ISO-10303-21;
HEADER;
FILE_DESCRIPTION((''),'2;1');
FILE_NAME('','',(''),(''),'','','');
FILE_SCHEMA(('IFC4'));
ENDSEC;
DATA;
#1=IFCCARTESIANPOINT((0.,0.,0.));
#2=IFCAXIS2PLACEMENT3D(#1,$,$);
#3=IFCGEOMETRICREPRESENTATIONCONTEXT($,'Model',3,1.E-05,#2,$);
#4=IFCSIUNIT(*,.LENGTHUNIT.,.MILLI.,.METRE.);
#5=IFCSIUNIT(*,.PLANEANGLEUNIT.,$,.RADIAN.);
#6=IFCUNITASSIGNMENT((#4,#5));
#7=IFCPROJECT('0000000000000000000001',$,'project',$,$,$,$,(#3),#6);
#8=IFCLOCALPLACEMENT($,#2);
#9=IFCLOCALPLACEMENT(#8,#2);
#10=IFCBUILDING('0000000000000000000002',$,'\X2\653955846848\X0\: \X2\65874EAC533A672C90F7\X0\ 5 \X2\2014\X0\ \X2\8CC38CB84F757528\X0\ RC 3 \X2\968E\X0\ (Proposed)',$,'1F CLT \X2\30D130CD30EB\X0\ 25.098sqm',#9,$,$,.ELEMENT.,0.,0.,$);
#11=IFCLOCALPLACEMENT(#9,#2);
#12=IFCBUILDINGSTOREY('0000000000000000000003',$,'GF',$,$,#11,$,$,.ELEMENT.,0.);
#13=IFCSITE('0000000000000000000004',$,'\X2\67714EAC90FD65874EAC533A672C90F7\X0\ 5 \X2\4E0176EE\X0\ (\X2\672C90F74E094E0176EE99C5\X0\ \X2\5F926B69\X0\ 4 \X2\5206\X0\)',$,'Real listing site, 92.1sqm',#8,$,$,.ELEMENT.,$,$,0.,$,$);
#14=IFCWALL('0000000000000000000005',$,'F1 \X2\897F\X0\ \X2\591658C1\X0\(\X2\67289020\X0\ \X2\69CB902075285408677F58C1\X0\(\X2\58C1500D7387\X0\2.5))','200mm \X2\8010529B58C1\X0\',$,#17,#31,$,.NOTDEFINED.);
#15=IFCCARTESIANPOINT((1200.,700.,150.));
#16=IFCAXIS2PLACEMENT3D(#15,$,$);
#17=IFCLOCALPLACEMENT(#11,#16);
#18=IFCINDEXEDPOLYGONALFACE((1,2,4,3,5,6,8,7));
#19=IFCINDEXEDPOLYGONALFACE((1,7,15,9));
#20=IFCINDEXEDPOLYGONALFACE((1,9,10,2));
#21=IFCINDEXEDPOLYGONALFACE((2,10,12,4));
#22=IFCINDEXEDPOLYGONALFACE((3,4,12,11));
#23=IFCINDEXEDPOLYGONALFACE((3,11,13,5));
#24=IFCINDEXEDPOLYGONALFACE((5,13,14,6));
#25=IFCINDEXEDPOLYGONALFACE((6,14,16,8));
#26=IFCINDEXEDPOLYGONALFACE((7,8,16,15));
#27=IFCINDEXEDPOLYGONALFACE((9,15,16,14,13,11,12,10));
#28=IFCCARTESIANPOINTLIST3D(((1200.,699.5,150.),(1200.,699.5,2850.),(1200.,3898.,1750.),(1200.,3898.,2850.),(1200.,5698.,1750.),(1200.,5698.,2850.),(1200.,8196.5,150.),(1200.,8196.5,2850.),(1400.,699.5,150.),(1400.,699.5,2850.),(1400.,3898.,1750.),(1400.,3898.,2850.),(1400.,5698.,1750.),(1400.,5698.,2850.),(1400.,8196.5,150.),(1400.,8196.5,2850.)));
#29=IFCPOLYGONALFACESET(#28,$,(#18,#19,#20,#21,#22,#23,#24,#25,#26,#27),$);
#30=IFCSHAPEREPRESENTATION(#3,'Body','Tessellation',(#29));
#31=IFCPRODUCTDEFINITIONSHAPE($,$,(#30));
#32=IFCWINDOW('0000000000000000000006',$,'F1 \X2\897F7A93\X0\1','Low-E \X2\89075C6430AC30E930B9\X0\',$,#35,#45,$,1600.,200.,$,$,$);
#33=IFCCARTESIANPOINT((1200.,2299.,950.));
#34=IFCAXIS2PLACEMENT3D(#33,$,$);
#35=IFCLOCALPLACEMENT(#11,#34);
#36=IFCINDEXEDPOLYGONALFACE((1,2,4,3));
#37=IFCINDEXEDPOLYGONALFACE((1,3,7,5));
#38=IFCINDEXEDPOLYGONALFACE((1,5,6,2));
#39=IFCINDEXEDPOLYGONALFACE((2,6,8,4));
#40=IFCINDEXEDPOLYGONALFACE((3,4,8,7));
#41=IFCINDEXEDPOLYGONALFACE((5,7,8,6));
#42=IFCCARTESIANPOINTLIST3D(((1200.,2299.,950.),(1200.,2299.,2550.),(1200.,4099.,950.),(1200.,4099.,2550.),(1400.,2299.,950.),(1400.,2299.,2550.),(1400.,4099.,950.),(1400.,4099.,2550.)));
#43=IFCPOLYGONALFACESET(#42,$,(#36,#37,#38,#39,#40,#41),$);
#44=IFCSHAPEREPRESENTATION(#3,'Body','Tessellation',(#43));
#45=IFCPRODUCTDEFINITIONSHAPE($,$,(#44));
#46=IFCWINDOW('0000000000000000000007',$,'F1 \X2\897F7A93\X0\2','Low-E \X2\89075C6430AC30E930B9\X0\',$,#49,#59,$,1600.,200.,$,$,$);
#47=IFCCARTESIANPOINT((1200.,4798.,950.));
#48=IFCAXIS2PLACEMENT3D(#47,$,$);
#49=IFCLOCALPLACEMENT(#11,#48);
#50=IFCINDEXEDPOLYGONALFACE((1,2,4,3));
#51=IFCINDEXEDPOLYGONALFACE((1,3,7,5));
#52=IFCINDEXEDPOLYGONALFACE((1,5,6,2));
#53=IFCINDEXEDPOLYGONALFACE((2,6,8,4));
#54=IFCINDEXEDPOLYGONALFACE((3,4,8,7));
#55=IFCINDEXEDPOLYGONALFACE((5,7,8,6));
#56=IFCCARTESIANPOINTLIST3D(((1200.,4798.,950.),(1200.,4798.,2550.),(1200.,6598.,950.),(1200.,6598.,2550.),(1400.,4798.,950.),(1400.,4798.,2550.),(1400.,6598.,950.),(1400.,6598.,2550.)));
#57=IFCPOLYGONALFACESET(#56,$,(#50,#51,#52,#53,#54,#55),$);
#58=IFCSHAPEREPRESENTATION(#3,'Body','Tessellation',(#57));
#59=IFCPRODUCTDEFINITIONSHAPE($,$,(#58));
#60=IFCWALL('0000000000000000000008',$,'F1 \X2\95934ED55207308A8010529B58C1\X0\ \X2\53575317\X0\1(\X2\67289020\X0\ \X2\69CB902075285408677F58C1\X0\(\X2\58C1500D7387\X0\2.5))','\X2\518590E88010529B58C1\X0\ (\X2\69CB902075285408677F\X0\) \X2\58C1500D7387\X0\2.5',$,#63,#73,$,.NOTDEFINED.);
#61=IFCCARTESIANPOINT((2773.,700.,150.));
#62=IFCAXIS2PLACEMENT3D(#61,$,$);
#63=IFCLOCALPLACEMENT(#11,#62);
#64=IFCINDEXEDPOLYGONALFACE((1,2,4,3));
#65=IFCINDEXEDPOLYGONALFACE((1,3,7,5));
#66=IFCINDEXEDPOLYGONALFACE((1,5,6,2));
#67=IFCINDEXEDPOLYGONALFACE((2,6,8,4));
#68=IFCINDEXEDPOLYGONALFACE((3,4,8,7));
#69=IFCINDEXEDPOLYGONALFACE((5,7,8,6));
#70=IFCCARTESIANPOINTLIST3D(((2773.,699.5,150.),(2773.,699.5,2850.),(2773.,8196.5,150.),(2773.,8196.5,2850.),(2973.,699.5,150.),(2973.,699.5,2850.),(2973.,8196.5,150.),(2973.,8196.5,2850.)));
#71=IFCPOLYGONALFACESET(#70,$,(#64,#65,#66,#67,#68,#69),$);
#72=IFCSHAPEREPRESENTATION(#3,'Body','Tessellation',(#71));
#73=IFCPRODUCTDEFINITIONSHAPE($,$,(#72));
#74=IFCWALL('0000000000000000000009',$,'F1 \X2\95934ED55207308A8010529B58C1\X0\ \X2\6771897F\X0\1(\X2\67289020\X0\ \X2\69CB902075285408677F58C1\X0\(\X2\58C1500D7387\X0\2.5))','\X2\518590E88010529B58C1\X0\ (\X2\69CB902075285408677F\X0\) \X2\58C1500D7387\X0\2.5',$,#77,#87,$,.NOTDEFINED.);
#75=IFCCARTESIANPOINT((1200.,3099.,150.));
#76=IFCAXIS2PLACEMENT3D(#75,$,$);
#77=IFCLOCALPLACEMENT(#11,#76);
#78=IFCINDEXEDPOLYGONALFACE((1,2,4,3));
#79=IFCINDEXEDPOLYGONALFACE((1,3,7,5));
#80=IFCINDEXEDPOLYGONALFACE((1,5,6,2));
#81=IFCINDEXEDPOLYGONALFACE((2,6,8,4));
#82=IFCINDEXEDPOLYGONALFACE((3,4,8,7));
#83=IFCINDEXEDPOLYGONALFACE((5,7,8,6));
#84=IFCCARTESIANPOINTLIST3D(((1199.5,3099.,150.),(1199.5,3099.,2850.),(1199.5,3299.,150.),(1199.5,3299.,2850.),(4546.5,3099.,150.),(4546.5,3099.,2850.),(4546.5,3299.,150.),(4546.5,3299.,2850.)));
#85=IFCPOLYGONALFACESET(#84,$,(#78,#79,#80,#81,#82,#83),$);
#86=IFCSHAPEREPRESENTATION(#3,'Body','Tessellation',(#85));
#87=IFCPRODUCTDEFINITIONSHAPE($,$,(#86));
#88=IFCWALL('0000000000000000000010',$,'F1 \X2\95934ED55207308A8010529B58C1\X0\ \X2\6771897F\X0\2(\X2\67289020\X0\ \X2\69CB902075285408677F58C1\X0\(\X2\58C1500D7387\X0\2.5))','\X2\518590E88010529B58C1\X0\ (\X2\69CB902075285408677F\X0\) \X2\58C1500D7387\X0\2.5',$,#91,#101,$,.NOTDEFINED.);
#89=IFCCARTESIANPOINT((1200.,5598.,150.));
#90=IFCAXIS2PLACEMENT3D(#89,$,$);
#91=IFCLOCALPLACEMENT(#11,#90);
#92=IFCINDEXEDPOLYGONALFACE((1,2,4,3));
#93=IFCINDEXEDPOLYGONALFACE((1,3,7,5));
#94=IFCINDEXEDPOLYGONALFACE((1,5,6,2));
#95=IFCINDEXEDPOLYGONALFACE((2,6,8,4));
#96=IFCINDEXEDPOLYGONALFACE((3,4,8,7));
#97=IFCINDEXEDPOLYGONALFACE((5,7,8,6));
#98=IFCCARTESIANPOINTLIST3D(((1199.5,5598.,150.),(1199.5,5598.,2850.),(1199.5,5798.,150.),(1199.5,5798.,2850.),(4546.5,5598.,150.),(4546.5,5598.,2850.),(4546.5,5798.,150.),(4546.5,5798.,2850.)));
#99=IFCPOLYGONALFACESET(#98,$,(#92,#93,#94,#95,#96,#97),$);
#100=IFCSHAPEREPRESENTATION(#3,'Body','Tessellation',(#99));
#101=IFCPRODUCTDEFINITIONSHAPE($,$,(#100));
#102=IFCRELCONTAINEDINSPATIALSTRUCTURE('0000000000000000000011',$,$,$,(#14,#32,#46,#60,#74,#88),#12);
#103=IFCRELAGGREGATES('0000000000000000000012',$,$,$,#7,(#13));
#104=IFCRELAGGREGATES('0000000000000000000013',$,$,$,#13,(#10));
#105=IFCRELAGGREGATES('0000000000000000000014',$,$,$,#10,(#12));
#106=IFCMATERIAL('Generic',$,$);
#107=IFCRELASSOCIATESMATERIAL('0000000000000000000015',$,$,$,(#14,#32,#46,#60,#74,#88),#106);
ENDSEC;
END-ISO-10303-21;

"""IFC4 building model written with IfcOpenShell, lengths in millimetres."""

from ifc_helpers import new_model, si_unit, frame, frame_2d, origin, place, context, project, spatial, rectangle, extrude, material, element, fill, save


model = new_model("IFC4")

# Units and contexts
model_context = context("Model", 3, precision=1e-05, world=origin())
ifc_project = project(units=[si_unit("LENGTHUNIT", "METRE", prefix="MILLI"), si_unit("PLANEANGLEUNIT", "RADIAN")], contexts=[model_context])

# Site, building, storey
site_placement = place(None, origin())
site = spatial("IfcSite", under=ifc_project, at=site_placement, Name="東京都文京区本郷 5 丁目 (本郷三丁目駅 徒歩 4 分)", ObjectType="Real listing site, 92.1sqm", CompositionType="ELEMENT", RefElevation=0.0)
building_placement = place(site_placement, origin())
building = spatial("IfcBuilding", under=site, at=building_placement, Name="改善案: 文京区本郷 5 — 賃貸併用 RC 3 階 (Proposed)", ObjectType="1F CLT パネル 25.098sqm", CompositionType="ELEMENT", ElevationOfRefHeight=0.0, ElevationOfTerrain=0.0)
storey_placement = place(building_placement, origin())
storey = spatial("IfcBuildingStorey", under=building, at=storey_placement, Name="GF", CompositionType="ELEMENT", Elevation=0.0)

# Shared definitions
ifc_material_1 = material(Name="Generic")

# Wall, openings, windows
wall_1_placement = place(storey_placement, frame((1200.0, 700.0, 150.0)))
wall_1 = element("IfcWall", 1, at=wall_1_placement, inside=storey, material=ifc_material_1, Name="F1 西 外壁(木造 構造用合板壁(壁倍率2.5))", Description="200mm 耐力壁", PredefinedType="NOTDEFINED", context=model_context, shape_type="SweptSolid", body=[
    extrude(rectangle(XDim=200.0, YDim=7497.0, at=frame_2d((100.0, 3748.0))), frame((1200.0, 700.0, 150.0)), (0.0, 0.0, 1.0), 2700.0),
])
opening_1_placement = place(storey_placement, frame((1200.0, 2299.0, 950.0)))
opening_1 = element("IfcOpeningElement", 2, at=opening_1_placement, cuts=wall_1, PredefinedType="NOTDEFINED", context=model_context, shape_type="SweptSolid", body=[
    extrude(rectangle(XDim=200.0, YDim=1800.0, at=frame_2d((100.0, 900.0))), frame((1200.0, 2299.0, 950.0)), (0.0, 0.0, 1.0), 1600.0),
])
opening_2_placement = place(storey_placement, frame((1200.0, 4798.0, 950.0)))
opening_2 = element("IfcOpeningElement", 3, at=opening_2_placement, cuts=wall_1, PredefinedType="NOTDEFINED", context=model_context, shape_type="SweptSolid", body=[
    extrude(rectangle(XDim=200.0, YDim=1800.0, at=frame_2d((100.0, 900.0))), frame((1200.0, 4798.0, 950.0)), (0.0, 0.0, 1.0), 1600.0),
])
window_1_placement = place(storey_placement, frame((1200.0, 2299.0, 950.0)))
window_1 = element("IfcWindow", 4, at=window_1_placement, inside=storey, material=ifc_material_1, Name="F1 西窓1", Description="Low-E 複層ガラス", OverallHeight=1600.0, OverallWidth=200.0, context=model_context, shape_type="SweptSolid", body=[
    extrude(rectangle(XDim=200.0, YDim=1800.0, at=frame_2d((100.0, 900.0))), frame((1200.0, 2299.0, 950.0)), (0.0, 0.0, 1.0), 1600.0),
])
fill(opening_1, window_1)
window_2_placement = place(storey_placement, frame((1200.0, 4798.0, 950.0)))
window_2 = element("IfcWindow", 5, at=window_2_placement, inside=storey, material=ifc_material_1, Name="F1 西窓2", Description="Low-E 複層ガラス", OverallHeight=1600.0, OverallWidth=200.0, context=model_context, shape_type="SweptSolid", body=[
    extrude(rectangle(XDim=200.0, YDim=1800.0, at=frame_2d((100.0, 900.0))), frame((1200.0, 4798.0, 950.0)), (0.0, 0.0, 1.0), 1600.0),
])
fill(opening_2, window_2)

# Walls
wall_2_placement = place(storey_placement, frame((2773.0, 700.0, 150.0)))
element("IfcWall", 6, at=wall_2_placement, inside=storey, material=ifc_material_1, Name="F1 間仕切り耐力壁 南北1(木造 構造用合板壁(壁倍率2.5))", Description="内部耐力壁 (構造用合板) 壁倍率2.5", PredefinedType="NOTDEFINED", context=model_context, shape_type="SweptSolid", body=[
    extrude(rectangle(XDim=200.0, YDim=7497.0, at=frame_2d((100.0, 3748.0))), frame((2773.0, 700.0, 150.0)), (0.0, 0.0, 1.0), 2700.0),
])
wall_3_placement = place(storey_placement, frame((1200.0, 3099.0, 150.0)))
element("IfcWall", 7, at=wall_3_placement, inside=storey, material=ifc_material_1, Name="F1 間仕切り耐力壁 東西1(木造 構造用合板壁(壁倍率2.5))", Description="内部耐力壁 (構造用合板) 壁倍率2.5", PredefinedType="NOTDEFINED", context=model_context, shape_type="SweptSolid", body=[
    extrude(rectangle(XDim=3347.0, YDim=200.0, at=frame_2d((1673.0, 100.0))), frame((1200.0, 3099.0, 150.0)), (0.0, 0.0, 1.0), 2700.0),
])
wall_4_placement = place(storey_placement, frame((1200.0, 5598.0, 150.0)))
element("IfcWall", 8, at=wall_4_placement, inside=storey, material=ifc_material_1, Name="F1 間仕切り耐力壁 東西2(木造 構造用合板壁(壁倍率2.5))", Description="内部耐力壁 (構造用合板) 壁倍率2.5", PredefinedType="NOTDEFINED", context=model_context, shape_type="SweptSolid", body=[
    extrude(rectangle(XDim=3347.0, YDim=200.0, at=frame_2d((1673.0, 100.0))), frame((1200.0, 5598.0, 150.0)), (0.0, 0.0, 1.0), 2700.0),
])

save(model, "model.ifc")
